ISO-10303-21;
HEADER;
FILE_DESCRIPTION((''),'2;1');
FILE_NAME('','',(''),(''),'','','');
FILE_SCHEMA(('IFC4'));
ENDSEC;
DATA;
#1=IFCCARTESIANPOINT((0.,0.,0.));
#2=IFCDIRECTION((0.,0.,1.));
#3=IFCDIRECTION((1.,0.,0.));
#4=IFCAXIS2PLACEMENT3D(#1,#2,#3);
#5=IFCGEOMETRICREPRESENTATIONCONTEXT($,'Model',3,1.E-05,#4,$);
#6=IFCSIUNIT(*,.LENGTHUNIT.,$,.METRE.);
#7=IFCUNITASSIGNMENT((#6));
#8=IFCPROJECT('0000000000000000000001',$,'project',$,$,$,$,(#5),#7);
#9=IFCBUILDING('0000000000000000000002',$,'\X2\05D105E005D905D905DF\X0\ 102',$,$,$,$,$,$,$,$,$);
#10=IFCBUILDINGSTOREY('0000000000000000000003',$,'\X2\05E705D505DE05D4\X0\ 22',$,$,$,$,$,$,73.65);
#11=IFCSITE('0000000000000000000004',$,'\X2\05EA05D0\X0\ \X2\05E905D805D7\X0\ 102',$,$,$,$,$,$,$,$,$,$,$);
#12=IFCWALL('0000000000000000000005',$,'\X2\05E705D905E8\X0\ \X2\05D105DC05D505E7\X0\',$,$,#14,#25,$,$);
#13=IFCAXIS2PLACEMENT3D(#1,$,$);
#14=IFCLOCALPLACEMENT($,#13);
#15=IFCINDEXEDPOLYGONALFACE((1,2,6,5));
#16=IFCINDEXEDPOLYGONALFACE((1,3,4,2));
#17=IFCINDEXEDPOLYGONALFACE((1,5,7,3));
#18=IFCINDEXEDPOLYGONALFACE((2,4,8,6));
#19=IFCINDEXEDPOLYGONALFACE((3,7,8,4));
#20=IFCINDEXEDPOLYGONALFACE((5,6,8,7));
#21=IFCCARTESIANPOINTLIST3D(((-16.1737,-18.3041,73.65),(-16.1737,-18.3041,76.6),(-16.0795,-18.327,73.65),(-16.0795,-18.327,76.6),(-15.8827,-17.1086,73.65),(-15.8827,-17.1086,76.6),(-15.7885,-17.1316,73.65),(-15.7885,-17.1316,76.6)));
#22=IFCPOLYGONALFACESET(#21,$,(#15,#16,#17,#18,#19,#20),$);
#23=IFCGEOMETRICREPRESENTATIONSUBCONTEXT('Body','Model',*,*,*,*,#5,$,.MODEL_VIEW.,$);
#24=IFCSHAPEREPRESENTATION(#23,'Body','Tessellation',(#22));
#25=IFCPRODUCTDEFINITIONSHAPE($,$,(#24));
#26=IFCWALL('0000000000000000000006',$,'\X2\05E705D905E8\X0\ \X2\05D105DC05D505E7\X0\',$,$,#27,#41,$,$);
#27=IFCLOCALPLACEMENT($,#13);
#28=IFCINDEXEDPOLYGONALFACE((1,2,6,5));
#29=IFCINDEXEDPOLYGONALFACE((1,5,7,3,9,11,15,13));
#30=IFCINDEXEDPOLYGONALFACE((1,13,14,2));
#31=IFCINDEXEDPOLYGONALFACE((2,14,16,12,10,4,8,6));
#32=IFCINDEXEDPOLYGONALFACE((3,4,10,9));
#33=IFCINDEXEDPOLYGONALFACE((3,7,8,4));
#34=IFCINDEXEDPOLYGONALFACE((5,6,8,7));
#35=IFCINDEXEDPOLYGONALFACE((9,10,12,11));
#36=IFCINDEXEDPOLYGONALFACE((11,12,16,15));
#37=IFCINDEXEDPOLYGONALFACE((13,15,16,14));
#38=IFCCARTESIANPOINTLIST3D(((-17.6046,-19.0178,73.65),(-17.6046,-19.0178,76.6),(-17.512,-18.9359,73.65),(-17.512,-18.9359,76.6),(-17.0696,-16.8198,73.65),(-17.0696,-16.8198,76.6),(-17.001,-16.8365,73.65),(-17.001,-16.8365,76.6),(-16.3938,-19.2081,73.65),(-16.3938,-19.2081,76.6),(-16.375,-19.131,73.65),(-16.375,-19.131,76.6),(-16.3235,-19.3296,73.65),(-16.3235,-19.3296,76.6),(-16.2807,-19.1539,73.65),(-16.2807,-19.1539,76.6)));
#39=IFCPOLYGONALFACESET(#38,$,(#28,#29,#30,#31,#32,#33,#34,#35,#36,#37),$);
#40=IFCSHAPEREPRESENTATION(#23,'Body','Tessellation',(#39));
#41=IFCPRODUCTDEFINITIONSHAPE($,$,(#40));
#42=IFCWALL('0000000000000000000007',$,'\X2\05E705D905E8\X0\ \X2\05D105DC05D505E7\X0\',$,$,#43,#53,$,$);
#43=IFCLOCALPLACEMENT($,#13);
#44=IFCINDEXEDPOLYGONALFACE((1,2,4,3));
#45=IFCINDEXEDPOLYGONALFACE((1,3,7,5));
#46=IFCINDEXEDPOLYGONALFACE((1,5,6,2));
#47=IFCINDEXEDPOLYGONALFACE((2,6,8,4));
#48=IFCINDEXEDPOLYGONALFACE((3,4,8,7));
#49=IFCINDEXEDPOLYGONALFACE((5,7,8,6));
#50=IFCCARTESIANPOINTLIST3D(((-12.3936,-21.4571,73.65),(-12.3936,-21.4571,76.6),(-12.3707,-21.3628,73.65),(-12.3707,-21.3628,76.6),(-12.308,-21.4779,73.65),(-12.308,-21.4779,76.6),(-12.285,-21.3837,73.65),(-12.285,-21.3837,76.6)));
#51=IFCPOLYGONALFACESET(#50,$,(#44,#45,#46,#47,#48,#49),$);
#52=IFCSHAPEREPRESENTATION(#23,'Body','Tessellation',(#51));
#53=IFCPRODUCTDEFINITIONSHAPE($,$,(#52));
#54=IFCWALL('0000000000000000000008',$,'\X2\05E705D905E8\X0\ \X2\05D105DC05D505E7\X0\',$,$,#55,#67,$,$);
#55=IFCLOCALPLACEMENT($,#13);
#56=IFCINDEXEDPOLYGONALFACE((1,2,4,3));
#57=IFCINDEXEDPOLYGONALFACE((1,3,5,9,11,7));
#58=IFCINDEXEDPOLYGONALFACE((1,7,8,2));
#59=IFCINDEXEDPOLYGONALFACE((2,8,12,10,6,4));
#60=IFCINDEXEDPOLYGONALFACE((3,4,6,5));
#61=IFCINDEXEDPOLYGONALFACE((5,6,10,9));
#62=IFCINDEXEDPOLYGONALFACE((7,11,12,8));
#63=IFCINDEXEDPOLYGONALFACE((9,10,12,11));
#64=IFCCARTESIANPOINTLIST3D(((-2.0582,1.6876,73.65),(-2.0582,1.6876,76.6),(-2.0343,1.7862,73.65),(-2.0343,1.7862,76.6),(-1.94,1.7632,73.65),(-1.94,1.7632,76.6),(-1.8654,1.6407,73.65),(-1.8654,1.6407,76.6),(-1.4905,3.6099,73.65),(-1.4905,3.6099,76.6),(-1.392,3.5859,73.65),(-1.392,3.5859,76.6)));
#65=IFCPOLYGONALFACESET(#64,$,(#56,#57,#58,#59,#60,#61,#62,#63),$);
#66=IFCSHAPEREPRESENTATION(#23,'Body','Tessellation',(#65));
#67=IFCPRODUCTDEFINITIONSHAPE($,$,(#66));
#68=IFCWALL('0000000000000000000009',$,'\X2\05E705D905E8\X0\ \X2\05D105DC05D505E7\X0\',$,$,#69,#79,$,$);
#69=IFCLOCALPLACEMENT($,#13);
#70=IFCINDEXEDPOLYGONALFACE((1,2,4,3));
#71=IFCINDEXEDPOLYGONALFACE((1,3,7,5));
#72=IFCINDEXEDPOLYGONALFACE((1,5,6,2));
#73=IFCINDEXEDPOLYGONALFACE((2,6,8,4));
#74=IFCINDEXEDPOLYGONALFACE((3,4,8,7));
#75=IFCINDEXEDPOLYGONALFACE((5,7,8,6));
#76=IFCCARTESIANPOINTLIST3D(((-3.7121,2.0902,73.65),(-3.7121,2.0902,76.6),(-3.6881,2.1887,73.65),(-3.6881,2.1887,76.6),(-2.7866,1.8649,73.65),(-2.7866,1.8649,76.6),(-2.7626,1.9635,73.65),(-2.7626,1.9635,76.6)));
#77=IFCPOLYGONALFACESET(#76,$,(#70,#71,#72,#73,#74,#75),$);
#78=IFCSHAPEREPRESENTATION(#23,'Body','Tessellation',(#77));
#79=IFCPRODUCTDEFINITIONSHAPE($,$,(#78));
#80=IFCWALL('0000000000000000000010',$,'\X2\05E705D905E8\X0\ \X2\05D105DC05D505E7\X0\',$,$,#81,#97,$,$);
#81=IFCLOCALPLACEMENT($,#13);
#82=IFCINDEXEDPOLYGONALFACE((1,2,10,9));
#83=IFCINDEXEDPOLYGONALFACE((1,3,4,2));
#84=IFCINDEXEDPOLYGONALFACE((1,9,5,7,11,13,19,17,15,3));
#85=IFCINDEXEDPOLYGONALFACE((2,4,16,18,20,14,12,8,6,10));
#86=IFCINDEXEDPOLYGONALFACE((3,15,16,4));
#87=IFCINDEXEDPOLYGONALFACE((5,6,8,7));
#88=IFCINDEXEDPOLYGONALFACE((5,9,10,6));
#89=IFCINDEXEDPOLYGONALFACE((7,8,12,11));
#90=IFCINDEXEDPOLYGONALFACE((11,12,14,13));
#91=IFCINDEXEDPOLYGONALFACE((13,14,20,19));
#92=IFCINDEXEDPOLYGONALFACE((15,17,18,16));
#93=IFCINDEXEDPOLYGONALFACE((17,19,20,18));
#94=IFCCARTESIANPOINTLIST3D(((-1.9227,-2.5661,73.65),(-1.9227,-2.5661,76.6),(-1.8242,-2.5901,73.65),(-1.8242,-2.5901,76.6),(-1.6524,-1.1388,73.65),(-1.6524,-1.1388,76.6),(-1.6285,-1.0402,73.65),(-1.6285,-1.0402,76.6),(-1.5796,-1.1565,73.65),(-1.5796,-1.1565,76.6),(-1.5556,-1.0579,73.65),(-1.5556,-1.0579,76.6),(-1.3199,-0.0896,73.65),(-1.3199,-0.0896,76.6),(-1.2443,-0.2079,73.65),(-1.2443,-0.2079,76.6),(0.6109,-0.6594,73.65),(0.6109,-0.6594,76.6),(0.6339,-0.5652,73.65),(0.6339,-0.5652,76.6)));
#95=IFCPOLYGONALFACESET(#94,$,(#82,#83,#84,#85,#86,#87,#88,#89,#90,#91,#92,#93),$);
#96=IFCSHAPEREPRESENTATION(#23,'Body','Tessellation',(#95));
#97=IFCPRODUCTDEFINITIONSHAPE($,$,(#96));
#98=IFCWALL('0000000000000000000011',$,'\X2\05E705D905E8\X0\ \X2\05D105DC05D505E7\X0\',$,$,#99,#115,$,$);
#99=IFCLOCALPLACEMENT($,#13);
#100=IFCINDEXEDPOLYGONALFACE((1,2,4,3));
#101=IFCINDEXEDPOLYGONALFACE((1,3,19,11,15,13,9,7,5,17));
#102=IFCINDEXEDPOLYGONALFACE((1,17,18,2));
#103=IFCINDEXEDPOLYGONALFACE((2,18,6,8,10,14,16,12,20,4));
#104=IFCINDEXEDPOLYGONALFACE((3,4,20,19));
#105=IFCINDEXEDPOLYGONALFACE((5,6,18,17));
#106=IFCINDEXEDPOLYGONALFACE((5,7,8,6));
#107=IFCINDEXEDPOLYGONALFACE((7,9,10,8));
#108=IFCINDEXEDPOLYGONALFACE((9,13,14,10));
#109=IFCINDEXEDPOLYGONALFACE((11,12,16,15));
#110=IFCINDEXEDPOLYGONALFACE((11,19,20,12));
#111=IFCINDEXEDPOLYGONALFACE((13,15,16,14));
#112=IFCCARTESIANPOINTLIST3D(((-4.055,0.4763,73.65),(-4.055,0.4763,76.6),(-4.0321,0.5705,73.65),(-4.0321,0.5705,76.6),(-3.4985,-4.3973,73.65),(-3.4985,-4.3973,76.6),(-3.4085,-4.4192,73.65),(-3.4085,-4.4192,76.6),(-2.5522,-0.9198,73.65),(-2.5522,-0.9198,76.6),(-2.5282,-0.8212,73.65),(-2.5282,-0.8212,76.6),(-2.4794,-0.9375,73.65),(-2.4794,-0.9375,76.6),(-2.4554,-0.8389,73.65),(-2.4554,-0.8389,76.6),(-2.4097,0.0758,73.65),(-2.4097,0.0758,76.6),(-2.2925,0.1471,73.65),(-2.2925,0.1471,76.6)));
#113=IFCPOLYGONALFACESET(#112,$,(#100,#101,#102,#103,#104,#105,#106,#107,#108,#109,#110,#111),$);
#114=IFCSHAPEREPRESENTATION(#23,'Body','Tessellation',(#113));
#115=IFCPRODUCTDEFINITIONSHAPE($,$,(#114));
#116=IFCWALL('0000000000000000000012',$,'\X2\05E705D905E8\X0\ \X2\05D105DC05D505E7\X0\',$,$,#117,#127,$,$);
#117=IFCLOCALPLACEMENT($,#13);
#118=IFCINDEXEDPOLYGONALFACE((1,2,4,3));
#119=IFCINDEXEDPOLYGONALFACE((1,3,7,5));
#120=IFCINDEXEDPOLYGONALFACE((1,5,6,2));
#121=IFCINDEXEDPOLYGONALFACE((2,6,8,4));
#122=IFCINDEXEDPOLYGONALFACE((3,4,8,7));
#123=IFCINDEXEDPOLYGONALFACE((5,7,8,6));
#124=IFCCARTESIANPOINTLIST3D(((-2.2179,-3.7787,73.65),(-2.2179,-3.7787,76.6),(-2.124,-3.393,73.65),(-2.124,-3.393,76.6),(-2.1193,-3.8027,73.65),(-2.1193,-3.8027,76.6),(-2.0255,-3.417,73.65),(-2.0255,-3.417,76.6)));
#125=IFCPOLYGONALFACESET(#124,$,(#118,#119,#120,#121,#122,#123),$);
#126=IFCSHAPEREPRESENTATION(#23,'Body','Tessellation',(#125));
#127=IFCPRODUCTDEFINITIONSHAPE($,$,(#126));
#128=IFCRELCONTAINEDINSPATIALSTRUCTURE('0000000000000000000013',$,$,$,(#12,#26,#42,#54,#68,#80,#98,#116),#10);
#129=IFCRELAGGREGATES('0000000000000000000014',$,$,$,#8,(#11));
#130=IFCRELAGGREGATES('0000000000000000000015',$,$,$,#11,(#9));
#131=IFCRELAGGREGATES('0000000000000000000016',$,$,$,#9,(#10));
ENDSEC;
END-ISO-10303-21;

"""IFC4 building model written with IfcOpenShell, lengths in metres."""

from ifc_helpers import new_model, si_unit, frame, origin_with_axes, context, subcontext, project, spatial, polyline, outline, extrude, element, save


model = new_model("IFC4")

# Units and contexts
model_context = context("Model", 3, precision=1e-05, world=origin_with_axes())
body_context = subcontext(model_context, "Body", "Model", "MODEL_VIEW")
ifc_project = project(units=[si_unit("LENGTHUNIT", "METRE")], contexts=[model_context])

# Site, building, storey
site = spatial("IfcSite", under=ifc_project, Name="תא שטח 102")
building = spatial("IfcBuilding", under=site, Name="בניין 102")
storey = spatial("IfcBuildingStorey", under=building, Name="קומה 22", Elevation=73.65)

# Walls
element("IfcWall", 1, inside=storey, Name="קיר בלוק", context=body_context, shape_type="SweptSolid", body=[
    extrude(outline(polyline([(-16.1737, -18.3041), (-16.0795, -18.327), (-15.7885, -17.1316), (-15.8827, -17.1086), (-16.1737, -18.3041)])), frame((0.0, 0.0, 73.65)), (0.0, 0.0, 1.0), 2.95),
])
element("IfcWall", 2, inside=storey, Name="קיר בלוק", context=body_context, shape_type="SweptSolid", body=[
    extrude(outline(polyline([(-17.6046, -19.0178), (-16.3235, -19.3296), (-16.2807, -19.1539), (-16.375, -19.131), (-16.3938, -19.2081), (-17.512, -18.9359), (-17.001, -16.8365), (-17.0696, -16.8198), (-17.6046, -19.0178)])), frame((0.0, 0.0, 73.65)), (0.0, 0.0, 1.0), 2.95),
])
element("IfcWall", 3, inside=storey, Name="קיר בלוק", context=body_context, shape_type="SweptSolid", body=[
    extrude(outline(polyline([(-12.285, -21.3837), (-12.3707, -21.3628), (-12.3936, -21.4571), (-12.308, -21.4779), (-12.285, -21.3837)])), frame((0.0, 0.0, 73.65)), (0.0, 0.0, 1.0), 2.95),
])
element("IfcWall", 4, inside=storey, Name="קיר בלוק", context=body_context, shape_type="SweptSolid", body=[
    extrude(outline(polyline([(-2.0582, 1.6876), (-1.8654, 1.6407), (-1.392, 3.5859), (-1.4905, 3.6099), (-1.94, 1.7632), (-2.0343, 1.7862), (-2.0582, 1.6876)])), frame((0.0, 0.0, 73.65)), (0.0, 0.0, 1.0), 2.95),
])
element("IfcWall", 5, inside=storey, Name="קיר בלוק", context=body_context, shape_type="SweptSolid", body=[
    extrude(outline(polyline([(-2.7626, 1.9635), (-3.6881, 2.1887), (-3.7121, 2.0902), (-2.7866, 1.8649), (-2.7626, 1.9635)])), frame((0.0, 0.0, 73.65)), (0.0, 0.0, 1.0), 2.95),
])
element("IfcWall", 6, inside=storey, Name="קיר בלוק", context=body_context, shape_type="SweptSolid", body=[
    extrude(outline(polyline([(-1.6524, -1.1388), (-1.5796, -1.1565), (-1.9227, -2.5661), (-1.8242, -2.5901), (-1.2443, -0.2079), (0.6109, -0.6594), (0.6339, -0.5652), (-1.3199, -0.0896), (-1.5556, -1.0579), (-1.6285, -1.0402), (-1.6524, -1.1388)])), frame((0.0, 0.0, 73.65)), (0.0, 0.0, 1.0), 2.95),
])
element("IfcWall", 7, inside=storey, Name="קיר בלוק", context=body_context, shape_type="SweptSolid", body=[
    extrude(outline(polyline([(-3.4085, -4.4192), (-2.5522, -0.9198), (-2.4794, -0.9375), (-2.4554, -0.8389), (-2.5282, -0.8212), (-2.2925, 0.1471), (-4.0321, 0.5705), (-4.055, 0.4763), (-2.4097, 0.0758), (-3.4985, -4.3973), (-3.4085, -4.4192)])), frame((0.0, 0.0, 73.65)), (0.0, 0.0, 1.0), 2.95),
])
element("IfcWall", 8, inside=storey, Name="קיר בלוק", context=body_context, shape_type="SweptSolid", body=[
    extrude(outline(polyline([(-2.0255, -3.417), (-2.124, -3.393), (-2.2179, -3.7787), (-2.1193, -3.8027), (-2.0255, -3.417)])), frame((0.0, 0.0, 73.65)), (0.0, 0.0, 1.0), 2.95),
])

save(model, "model.ifc")
